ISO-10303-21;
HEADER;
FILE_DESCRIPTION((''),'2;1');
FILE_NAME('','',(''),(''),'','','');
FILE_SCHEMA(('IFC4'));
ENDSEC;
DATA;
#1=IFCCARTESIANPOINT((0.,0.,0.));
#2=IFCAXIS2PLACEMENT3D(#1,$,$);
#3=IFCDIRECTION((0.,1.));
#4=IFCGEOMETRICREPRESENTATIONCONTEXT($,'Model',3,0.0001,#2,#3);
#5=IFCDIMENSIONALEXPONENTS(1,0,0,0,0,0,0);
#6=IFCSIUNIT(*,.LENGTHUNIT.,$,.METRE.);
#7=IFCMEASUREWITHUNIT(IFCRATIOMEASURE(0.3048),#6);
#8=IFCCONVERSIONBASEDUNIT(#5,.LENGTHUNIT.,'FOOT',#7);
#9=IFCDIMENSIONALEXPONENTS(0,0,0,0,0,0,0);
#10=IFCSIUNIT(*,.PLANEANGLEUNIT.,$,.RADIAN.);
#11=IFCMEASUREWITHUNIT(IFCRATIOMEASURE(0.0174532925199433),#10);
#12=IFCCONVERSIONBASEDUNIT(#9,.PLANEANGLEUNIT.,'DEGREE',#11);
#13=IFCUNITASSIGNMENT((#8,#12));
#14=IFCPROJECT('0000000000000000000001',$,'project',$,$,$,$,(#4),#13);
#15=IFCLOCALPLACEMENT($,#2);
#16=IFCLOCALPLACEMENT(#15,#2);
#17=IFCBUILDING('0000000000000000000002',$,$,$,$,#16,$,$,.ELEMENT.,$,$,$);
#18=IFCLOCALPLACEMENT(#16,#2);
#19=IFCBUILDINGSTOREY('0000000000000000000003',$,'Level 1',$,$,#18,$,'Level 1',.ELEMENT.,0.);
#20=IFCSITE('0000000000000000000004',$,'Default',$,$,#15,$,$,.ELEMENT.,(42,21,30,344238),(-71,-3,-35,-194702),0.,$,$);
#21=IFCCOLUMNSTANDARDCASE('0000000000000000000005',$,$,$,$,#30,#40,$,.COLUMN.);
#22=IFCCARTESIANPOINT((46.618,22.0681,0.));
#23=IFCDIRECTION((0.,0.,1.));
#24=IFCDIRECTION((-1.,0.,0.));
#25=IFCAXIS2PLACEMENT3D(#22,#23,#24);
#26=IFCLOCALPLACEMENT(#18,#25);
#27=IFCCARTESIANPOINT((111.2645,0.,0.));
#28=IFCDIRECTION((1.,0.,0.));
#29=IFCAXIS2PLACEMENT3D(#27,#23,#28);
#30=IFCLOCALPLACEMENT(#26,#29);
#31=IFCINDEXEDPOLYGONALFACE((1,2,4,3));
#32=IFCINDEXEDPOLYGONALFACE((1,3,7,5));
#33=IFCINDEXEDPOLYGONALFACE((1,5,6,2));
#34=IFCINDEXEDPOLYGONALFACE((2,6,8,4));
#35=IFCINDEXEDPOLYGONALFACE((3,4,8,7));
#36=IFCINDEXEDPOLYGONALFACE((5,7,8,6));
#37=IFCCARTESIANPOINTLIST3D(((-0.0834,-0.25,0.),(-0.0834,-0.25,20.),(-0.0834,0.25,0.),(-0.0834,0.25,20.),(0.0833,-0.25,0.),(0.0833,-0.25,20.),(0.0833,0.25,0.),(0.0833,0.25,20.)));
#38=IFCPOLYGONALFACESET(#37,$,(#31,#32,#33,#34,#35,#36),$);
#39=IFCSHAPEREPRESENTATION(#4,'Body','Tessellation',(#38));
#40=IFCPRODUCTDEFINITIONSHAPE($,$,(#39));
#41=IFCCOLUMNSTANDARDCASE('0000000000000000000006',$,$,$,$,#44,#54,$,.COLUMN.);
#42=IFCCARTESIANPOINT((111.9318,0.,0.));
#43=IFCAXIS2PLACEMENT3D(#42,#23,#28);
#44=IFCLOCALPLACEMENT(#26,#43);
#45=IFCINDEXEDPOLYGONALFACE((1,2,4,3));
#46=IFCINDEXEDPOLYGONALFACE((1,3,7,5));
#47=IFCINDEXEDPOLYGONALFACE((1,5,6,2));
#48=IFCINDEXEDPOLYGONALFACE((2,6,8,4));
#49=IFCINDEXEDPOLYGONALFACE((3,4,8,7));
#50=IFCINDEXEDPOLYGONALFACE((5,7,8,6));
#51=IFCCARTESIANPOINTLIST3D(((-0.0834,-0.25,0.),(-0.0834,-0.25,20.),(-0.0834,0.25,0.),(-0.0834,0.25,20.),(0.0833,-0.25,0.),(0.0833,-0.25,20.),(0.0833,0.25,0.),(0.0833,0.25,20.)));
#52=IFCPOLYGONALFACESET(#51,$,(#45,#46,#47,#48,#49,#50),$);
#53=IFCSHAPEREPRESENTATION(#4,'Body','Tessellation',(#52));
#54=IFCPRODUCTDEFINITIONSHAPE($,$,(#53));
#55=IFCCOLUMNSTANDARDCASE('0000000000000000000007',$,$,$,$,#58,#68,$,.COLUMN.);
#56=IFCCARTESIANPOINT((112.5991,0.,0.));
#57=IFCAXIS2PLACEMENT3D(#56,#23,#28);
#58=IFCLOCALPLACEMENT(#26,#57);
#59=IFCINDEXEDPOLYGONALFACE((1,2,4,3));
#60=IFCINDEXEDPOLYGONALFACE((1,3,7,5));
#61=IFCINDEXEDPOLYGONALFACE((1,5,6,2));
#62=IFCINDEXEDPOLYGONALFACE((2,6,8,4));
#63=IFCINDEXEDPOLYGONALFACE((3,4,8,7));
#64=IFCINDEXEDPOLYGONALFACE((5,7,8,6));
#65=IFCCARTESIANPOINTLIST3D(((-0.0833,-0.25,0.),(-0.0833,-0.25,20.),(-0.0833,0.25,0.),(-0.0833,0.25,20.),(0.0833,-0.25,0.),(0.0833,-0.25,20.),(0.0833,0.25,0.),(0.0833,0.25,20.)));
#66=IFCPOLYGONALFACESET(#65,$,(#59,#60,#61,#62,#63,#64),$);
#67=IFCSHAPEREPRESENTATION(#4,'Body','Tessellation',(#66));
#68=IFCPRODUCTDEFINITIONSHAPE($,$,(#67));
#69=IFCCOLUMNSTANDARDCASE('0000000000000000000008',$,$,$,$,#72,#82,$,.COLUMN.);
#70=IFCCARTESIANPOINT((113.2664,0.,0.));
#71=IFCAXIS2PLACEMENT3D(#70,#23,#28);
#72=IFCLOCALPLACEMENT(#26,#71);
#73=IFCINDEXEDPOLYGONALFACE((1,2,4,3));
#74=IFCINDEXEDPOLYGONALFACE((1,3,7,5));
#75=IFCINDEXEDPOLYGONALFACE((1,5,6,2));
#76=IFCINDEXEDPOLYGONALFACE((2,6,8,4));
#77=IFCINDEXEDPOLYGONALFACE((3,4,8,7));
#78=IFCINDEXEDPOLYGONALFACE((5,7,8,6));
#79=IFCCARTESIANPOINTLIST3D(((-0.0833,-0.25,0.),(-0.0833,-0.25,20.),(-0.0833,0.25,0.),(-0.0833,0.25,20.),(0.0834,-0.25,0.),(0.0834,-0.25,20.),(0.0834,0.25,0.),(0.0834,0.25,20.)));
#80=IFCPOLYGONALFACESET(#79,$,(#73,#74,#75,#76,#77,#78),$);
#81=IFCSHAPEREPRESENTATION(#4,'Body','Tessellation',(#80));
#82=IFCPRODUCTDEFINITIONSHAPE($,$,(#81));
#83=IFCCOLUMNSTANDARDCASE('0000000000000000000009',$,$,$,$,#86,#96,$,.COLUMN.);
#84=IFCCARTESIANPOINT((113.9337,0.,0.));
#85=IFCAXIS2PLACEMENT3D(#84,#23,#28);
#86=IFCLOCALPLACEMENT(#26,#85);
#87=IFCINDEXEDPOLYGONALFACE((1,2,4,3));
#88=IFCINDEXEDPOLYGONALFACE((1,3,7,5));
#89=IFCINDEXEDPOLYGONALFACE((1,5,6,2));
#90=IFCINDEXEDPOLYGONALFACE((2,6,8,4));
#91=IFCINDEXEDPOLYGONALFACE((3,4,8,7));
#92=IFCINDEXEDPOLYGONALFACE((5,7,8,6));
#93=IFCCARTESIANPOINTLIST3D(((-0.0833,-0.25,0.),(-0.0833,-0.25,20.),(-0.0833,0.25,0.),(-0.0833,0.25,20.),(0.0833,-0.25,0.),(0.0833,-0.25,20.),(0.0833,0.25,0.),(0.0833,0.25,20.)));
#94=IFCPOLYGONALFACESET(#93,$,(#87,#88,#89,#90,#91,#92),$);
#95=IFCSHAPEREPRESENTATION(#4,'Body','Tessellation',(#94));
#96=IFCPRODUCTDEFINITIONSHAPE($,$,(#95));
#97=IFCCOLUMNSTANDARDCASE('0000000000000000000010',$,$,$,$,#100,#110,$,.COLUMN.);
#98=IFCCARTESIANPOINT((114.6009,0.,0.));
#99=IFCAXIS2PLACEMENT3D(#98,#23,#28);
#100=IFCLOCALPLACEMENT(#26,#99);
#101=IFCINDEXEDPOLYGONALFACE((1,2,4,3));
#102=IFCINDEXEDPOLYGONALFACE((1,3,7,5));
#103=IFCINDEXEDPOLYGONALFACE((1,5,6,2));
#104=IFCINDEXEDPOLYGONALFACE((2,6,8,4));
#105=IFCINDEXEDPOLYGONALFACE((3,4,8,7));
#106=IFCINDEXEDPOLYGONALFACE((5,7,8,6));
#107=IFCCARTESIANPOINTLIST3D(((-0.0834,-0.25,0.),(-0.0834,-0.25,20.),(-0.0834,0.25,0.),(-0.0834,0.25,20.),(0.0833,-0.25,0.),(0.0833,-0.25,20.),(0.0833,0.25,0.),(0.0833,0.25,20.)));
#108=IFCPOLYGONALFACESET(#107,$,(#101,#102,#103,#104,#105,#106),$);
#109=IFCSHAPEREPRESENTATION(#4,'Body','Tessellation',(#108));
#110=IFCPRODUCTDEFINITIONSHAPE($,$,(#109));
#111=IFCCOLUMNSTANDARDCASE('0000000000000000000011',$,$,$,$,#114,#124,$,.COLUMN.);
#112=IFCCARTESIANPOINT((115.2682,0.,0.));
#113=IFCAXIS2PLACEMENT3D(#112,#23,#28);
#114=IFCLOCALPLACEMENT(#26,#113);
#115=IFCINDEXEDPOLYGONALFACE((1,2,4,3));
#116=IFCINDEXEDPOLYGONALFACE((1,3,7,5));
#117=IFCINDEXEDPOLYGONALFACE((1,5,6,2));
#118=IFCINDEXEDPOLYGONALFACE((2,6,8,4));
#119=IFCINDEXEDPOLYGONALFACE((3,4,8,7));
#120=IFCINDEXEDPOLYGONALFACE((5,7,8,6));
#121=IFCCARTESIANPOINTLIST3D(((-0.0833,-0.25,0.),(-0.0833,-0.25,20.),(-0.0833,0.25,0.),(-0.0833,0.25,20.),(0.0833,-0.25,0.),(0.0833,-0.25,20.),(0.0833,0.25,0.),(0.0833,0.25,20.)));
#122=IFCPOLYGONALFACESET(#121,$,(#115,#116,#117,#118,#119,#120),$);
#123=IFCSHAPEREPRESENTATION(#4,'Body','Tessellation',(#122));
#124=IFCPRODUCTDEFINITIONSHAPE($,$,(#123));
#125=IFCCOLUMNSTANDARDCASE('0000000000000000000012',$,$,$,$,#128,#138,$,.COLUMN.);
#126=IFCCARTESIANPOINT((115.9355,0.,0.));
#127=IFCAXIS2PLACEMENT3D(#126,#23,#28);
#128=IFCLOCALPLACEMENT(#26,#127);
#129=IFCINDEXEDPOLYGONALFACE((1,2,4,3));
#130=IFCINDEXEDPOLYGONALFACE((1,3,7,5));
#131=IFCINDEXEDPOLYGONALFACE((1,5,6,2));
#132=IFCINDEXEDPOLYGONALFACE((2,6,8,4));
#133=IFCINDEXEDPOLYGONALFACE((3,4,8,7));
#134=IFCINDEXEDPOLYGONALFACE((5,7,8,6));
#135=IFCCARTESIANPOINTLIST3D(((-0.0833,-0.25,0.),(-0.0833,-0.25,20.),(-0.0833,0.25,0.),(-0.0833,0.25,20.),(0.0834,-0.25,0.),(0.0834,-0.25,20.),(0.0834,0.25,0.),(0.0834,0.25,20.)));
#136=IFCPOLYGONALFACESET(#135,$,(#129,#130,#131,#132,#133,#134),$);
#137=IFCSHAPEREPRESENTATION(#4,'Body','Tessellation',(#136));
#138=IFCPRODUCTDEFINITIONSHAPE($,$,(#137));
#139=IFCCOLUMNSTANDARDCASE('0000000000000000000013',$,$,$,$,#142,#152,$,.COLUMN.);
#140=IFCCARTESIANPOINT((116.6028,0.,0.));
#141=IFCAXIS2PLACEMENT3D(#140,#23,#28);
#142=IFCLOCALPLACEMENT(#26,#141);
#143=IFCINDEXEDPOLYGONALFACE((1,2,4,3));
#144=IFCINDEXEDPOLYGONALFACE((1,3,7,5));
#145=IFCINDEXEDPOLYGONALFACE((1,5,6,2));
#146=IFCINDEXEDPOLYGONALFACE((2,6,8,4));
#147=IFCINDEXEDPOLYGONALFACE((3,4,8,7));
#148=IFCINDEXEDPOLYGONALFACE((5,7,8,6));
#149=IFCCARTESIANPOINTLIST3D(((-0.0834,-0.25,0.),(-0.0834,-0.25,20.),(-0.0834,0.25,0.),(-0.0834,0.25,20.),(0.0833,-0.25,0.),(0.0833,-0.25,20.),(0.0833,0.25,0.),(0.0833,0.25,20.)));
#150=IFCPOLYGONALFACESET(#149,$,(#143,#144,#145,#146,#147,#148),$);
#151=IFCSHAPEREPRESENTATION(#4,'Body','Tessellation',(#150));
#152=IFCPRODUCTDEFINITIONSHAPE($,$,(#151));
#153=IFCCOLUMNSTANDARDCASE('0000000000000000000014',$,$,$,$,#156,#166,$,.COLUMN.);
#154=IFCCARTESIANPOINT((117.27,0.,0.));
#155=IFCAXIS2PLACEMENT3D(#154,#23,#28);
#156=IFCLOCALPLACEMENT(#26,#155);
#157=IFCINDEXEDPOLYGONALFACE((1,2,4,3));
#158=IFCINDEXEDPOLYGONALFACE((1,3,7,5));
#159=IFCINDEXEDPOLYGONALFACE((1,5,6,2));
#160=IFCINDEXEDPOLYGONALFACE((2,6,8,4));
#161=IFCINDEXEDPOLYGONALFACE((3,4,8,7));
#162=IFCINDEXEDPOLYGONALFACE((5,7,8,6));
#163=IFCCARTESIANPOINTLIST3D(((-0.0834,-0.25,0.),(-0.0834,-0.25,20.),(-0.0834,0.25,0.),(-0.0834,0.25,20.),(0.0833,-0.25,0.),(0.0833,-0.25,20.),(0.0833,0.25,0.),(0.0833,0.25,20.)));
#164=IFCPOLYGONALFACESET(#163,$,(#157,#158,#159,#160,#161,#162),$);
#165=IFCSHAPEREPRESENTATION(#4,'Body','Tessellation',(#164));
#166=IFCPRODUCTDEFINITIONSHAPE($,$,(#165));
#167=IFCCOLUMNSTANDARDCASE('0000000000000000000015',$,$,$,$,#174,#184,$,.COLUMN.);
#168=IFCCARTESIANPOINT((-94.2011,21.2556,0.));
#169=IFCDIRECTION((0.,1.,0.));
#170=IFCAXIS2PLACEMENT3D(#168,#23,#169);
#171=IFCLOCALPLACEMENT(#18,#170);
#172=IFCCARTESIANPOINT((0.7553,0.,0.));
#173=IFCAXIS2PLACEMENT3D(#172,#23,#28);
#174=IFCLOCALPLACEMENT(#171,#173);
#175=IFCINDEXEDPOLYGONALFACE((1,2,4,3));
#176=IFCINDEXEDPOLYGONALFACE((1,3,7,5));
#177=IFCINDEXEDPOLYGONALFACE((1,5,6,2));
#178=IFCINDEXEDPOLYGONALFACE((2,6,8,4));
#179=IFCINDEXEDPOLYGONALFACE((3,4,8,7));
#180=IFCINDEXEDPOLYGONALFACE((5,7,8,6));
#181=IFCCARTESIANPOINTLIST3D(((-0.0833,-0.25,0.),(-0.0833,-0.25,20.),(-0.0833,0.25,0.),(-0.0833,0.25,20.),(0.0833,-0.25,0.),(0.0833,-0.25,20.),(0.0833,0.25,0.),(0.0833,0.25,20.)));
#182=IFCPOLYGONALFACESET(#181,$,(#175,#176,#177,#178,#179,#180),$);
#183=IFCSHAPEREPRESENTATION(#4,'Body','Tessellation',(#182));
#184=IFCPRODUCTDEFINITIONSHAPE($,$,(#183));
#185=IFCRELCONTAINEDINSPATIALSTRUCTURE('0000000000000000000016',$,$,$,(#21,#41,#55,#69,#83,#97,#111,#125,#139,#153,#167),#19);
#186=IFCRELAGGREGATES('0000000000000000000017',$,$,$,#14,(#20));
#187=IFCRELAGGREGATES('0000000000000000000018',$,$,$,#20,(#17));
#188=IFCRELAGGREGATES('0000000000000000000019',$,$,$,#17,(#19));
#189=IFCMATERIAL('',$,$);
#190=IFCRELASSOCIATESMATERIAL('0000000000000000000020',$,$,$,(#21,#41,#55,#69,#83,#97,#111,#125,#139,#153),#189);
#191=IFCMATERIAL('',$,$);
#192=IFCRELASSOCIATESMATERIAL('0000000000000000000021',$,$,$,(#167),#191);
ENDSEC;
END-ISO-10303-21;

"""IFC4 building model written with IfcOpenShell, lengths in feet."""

from ifc_helpers import new_model, entity, si_unit, converted_unit, direction, frame, origin, place, context, project, spatial, rectangle, extrude, material, element, save


model = new_model("IFC4")

# Units and contexts
model_context = context("Model", 3, precision=0.0001, world=origin(), true_north=direction((0.0, 1.0)))
ifc_project = project(units=[converted_unit("LENGTHUNIT", "FOOT", entity("IfcRatioMeasure", 0.3048), si_unit("LENGTHUNIT", "METRE"), dimensions=[1, 0, 0, 0, 0, 0, 0]), converted_unit("PLANEANGLEUNIT", "DEGREE", entity("IfcRatioMeasure", 0.0174532925199433), si_unit("PLANEANGLEUNIT", "RADIAN"), dimensions=[0, 0, 0, 0, 0, 0, 0])], contexts=[model_context])

# Site, building, storey
site_placement = place(None, origin())
site = spatial("IfcSite", under=ifc_project, at=site_placement, Name="Default", CompositionType="ELEMENT", RefLatitude=(42, 21, 30, 344238), RefLongitude=(-71, -3, -35, -194702), RefElevation=0.0)
building_placement = place(site_placement, origin())
building = spatial("IfcBuilding", under=site, at=building_placement, CompositionType="ELEMENT")
storey_placement = place(building_placement, origin())
storey = spatial("IfcBuildingStorey", under=building, at=storey_placement, Name="Level 1", LongName="Level 1", CompositionType="ELEMENT", Elevation=0.0)

# Columns
ifc_material_1 = material(Name="")
placement = place(storey_placement, frame((46.618, 22.0681, 0.0), z_axis=(0.0, 0.0, 1.0), x_axis=(-1.0, 0.0, 0.0)))
for number, where, z_axis, x_axis in (
    (1, (111.2645, 0.0, 0.0), (0.0, 0.0, 1.0), (1.0, 0.0, 0.0)),
    (2, (111.9318, 0.0, 0.0), (0.0, 0.0, 1.0), (1.0, 0.0, 0.0)),
    (3, (112.5991, 0.0, 0.0), (0.0, 0.0, 1.0), (1.0, 0.0, 0.0)),
    (4, (113.2664, 0.0, 0.0), (0.0, 0.0, 1.0), (1.0, 0.0, 0.0)),
    (5, (113.9337, 0.0, 0.0), (0.0, 0.0, 1.0), (1.0, 0.0, 0.0)),
    (6, (114.6009, 0.0, 0.0), (0.0, 0.0, 1.0), (1.0, 0.0, 0.0)),
    (7, (115.2682, 0.0, 0.0), (0.0, 0.0, 1.0), (1.0, 0.0, 0.0)),
    (8, (115.9355, 0.0, 0.0), (0.0, 0.0, 1.0), (1.0, 0.0, 0.0)),
    (9, (116.6028, 0.0, 0.0), (0.0, 0.0, 1.0), (1.0, 0.0, 0.0)),
    (10, (117.27, 0.0, 0.0), (0.0, 0.0, 1.0), (1.0, 0.0, 0.0)),
):
    element("IfcColumnStandardCase", number, at=place(placement, frame(where, z_axis=z_axis, x_axis=x_axis)), inside=storey, material=ifc_material_1, PredefinedType="COLUMN", context=model_context, shape_type="SweptSolid", body=[
        extrude(rectangle(XDim=0.1667, YDim=0.5), origin(), (0.0, 0.0, 1.0), 20.0),
    ])
ifc_material_2 = material(Name="")
wall_1_placement = place(storey_placement, frame((-94.2011, 21.2556, 0.0), z_axis=(0.0, 0.0, 1.0), x_axis=(0.0, 1.0, 0.0)))
for number, where, z_axis, x_axis in (
    (11, (0.7553, 0.0, 0.0), (0.0, 0.0, 1.0), (1.0, 0.0, 0.0)),
):
    element("IfcColumnStandardCase", number, at=place(wall_1_placement, frame(where, z_axis=z_axis, x_axis=x_axis)), inside=storey, material=ifc_material_2, PredefinedType="COLUMN", context=model_context, shape_type="SweptSolid", body=[
        extrude(rectangle(XDim=0.1667, YDim=0.5), origin(), (0.0, 0.0, 1.0), 20.0),
    ])

save(model, "model.ifc")
